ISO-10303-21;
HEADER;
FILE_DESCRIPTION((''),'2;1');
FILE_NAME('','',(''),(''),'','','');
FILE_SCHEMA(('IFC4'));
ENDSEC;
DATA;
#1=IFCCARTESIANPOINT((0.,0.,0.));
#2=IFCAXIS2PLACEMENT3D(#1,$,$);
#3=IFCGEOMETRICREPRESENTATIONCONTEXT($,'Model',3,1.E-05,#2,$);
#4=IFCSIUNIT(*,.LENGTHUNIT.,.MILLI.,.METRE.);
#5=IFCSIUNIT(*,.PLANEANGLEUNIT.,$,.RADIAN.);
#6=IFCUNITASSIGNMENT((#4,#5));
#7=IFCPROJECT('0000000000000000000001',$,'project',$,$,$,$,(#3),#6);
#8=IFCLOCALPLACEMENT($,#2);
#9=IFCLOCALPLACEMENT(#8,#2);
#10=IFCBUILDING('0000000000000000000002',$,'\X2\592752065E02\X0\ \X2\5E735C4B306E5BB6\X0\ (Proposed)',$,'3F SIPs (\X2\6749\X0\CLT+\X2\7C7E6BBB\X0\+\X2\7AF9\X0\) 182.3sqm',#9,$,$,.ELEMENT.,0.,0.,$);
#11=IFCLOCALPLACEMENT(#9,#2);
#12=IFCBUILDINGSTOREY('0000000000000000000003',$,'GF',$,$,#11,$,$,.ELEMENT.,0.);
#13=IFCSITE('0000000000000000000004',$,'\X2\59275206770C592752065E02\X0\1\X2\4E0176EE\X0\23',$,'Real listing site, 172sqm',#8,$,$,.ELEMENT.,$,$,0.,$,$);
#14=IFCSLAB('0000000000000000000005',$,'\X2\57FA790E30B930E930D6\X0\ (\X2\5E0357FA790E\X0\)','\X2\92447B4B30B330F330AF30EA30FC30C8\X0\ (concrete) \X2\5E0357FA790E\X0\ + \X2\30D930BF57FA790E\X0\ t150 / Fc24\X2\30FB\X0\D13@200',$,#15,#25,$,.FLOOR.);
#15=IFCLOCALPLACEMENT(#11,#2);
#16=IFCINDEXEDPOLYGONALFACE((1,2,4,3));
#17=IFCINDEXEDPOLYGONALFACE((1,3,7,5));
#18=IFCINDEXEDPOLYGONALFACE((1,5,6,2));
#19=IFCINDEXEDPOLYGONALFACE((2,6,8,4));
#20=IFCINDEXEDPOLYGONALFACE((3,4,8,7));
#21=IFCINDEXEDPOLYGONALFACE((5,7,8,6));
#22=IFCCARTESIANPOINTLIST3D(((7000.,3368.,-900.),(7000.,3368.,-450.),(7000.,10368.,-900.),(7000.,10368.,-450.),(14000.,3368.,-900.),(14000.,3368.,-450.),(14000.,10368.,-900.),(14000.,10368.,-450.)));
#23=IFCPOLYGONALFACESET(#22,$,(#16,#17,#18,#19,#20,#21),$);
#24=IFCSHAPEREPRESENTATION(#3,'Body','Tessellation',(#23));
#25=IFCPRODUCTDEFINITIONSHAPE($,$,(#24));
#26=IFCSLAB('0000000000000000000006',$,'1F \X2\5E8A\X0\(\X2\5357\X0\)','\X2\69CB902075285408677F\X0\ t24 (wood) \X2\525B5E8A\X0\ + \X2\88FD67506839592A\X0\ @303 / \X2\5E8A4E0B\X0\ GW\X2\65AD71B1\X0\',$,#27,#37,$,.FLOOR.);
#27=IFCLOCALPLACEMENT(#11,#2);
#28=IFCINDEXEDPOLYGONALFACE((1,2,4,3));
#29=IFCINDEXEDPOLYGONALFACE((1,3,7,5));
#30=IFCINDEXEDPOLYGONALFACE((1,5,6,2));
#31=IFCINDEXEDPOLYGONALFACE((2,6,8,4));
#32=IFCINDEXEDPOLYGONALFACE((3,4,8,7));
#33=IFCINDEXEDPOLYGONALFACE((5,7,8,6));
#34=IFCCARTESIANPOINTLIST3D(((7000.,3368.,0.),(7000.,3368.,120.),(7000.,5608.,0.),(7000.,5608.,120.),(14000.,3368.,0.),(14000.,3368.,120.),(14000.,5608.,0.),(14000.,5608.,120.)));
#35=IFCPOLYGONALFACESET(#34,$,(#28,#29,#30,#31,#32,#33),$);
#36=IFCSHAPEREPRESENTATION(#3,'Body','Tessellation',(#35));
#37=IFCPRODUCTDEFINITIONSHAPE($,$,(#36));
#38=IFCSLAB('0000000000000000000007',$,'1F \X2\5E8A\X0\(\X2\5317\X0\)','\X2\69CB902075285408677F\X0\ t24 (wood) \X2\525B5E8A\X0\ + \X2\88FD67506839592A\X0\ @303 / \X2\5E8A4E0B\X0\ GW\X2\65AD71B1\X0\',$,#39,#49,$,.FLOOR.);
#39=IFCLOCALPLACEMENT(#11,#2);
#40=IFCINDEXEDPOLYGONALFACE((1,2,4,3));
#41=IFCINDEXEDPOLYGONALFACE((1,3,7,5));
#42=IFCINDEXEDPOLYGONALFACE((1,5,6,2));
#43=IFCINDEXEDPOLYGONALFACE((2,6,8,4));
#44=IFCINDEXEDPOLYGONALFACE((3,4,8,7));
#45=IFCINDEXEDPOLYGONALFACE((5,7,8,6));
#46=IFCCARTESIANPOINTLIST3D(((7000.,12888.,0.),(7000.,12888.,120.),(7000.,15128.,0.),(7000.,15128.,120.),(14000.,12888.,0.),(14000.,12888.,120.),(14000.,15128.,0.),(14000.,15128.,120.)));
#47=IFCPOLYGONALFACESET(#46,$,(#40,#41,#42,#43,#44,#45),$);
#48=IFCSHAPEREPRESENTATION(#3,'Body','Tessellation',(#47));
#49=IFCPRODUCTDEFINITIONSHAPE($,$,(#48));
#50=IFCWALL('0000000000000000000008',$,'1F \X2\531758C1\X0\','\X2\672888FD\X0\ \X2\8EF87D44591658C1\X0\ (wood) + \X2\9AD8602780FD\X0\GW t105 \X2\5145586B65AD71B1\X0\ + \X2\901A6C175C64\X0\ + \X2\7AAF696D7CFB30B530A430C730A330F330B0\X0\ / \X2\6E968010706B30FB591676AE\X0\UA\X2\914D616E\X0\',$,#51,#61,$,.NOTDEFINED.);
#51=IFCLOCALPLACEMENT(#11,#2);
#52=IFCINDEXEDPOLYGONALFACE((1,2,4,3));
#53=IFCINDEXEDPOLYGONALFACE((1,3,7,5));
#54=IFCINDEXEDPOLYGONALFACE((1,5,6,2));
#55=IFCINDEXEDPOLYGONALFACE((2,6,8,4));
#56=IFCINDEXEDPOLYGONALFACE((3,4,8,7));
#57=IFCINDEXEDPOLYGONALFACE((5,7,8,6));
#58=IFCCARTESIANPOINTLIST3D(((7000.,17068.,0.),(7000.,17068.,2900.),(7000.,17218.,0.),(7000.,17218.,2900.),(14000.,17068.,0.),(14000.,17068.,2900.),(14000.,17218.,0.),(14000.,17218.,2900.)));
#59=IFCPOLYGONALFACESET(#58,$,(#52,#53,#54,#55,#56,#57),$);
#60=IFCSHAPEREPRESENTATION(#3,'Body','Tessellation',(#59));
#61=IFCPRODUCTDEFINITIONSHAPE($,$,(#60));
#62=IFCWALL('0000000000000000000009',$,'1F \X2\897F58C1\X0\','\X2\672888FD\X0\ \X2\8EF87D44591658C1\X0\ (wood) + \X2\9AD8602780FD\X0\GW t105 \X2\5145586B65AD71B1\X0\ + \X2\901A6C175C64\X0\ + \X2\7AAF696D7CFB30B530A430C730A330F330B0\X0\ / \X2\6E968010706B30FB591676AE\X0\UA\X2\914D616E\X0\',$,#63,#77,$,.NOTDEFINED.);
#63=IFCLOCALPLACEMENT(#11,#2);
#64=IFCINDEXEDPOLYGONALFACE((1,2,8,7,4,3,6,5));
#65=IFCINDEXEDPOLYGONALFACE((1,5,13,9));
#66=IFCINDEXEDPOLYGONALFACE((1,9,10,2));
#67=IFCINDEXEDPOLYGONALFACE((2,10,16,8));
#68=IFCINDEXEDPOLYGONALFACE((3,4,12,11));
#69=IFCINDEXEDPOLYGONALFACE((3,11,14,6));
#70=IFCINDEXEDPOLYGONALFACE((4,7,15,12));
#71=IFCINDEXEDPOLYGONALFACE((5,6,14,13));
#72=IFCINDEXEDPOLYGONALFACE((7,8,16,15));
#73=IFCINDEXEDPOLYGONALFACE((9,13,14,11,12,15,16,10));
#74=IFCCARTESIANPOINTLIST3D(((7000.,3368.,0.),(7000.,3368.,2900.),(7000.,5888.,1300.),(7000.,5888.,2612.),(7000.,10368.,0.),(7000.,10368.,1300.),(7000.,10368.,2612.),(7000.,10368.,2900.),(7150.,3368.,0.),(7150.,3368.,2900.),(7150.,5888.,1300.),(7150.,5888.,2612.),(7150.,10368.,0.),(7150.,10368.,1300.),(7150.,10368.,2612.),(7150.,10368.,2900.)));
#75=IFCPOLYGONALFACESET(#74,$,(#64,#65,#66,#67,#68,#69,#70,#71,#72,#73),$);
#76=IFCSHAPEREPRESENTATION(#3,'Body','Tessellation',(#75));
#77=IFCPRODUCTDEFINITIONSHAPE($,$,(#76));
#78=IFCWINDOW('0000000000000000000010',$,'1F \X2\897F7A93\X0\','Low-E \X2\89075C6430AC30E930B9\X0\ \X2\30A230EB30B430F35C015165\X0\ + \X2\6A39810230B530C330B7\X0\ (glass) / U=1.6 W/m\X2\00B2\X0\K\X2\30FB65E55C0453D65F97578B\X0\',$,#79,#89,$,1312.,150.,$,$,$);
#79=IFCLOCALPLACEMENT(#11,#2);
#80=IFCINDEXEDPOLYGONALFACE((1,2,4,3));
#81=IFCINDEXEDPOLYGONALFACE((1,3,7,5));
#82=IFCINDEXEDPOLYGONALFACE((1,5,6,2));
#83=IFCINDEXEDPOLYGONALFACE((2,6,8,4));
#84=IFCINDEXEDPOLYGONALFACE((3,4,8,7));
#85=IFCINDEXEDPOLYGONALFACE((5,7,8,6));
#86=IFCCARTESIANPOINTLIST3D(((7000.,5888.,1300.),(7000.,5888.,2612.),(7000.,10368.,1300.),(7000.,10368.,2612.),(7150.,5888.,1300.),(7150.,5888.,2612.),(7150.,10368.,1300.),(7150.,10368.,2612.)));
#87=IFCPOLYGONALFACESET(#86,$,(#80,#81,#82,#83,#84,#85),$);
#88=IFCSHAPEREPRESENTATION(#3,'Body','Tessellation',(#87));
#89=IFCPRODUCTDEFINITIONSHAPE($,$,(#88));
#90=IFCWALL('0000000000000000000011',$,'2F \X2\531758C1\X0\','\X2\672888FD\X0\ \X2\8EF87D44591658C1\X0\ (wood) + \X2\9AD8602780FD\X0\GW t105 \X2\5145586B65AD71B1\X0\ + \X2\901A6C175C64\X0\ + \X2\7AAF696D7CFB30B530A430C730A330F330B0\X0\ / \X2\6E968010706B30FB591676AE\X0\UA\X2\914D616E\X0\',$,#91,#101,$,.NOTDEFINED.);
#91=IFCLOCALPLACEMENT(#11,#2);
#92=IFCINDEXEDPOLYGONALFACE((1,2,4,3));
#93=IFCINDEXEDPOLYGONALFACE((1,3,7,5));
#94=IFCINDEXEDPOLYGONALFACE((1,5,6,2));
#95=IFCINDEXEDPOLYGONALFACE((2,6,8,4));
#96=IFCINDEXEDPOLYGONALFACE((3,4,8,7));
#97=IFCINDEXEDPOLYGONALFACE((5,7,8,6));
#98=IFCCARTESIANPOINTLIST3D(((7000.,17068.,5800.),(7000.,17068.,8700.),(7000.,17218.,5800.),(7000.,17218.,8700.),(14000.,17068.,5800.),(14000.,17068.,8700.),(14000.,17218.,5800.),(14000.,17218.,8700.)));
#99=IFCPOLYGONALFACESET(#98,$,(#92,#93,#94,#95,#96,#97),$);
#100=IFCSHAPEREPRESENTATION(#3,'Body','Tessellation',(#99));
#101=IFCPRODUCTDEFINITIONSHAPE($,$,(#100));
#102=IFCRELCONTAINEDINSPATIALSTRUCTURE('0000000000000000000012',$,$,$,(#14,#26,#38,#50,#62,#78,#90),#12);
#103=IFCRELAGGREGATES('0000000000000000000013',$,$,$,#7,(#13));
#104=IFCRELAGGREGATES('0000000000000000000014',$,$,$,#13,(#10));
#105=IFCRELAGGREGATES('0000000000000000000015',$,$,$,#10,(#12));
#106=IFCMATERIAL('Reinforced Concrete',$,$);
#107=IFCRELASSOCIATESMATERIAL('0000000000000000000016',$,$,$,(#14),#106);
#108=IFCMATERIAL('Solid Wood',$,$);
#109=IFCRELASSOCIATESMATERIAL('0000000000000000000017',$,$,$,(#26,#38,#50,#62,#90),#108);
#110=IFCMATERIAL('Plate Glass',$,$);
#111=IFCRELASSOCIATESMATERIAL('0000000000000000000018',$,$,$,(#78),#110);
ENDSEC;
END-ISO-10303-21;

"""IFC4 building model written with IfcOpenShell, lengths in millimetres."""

from ifc_helpers import new_model, si_unit, frame, frame_2d, origin, place, context, project, spatial, rectangle, extrude, material, element, fill, save


model = new_model("IFC4")

# Units and contexts
model_context = context("Model", 3, precision=1e-05, world=origin())
ifc_project = project(units=[si_unit("LENGTHUNIT", "METRE", prefix="MILLI"), si_unit("PLANEANGLEUNIT", "RADIAN")], contexts=[model_context])

# Site, building, storey
site_placement = place(None, origin())
site = spatial("IfcSite", under=ifc_project, at=site_placement, Name="大分県大分市1丁目23", ObjectType="Real listing site, 172sqm", CompositionType="ELEMENT", RefElevation=0.0)
building_placement = place(site_placement, origin())
building = spatial("IfcBuilding", under=site, at=building_placement, Name="大分市 平屋の家 (Proposed)", ObjectType="3F SIPs (杉CLT+籾殻+竹) 182.3sqm", CompositionType="ELEMENT", ElevationOfRefHeight=0.0, ElevationOfTerrain=0.0)
storey_placement = place(building_placement, origin())
storey = spatial("IfcBuildingStorey", under=building, at=storey_placement, Name="GF", CompositionType="ELEMENT", Elevation=0.0)

# Slabs
ifc_material_1 = material(Name="Reinforced Concrete")
slab_1_placement = place(storey_placement, frame((3500.0, 1684.0, -450.0)))
element("IfcSlab", 1, at=slab_1_placement, inside=storey, material=ifc_material_1, Name="基礎スラブ (布基礎)", Description="鉄筋コンクリート (concrete) 布基礎 + ベタ基礎 t150 / Fc24・D13@200", PredefinedType="FLOOR", context=model_context, shape_type="SweptSolid", body=[
    extrude(rectangle(XDim=7000.0, YDim=7000.0, at=frame_2d((3500.0, 3500.0))), frame((3500.0, 1684.0, -450.0)), (0.0, 0.0, 1.0), 450.0),
])
ifc_material_2 = material(Name="Solid Wood")
slab_2_placement = place(storey_placement, frame((3500.0, 1684.0, 0.0)))
element("IfcSlab", 2, at=slab_2_placement, inside=storey, material=ifc_material_2, Name="1F 床(南)", Description="構造用合板 t24 (wood) 剛床 + 製材根太 @303 / 床下 GW断熱", PredefinedType="FLOOR", context=model_context, shape_type="SweptSolid", body=[
    extrude(rectangle(XDim=7000.0, YDim=2240.0, at=frame_2d((3500.0, 1120.0))), frame((3500.0, 1684.0, 0.0)), (0.0, 0.0, 1.0), 120.0),
])
slab_3_placement = place(storey_placement, frame((3500.0, 6444.0, 0.0)))
element("IfcSlab", 3, at=slab_3_placement, inside=storey, material=ifc_material_2, Name="1F 床(北)", Description="構造用合板 t24 (wood) 剛床 + 製材根太 @303 / 床下 GW断熱", PredefinedType="FLOOR", context=model_context, shape_type="SweptSolid", body=[
    extrude(rectangle(XDim=7000.0, YDim=2240.0, at=frame_2d((3500.0, 1120.0))), frame((3500.0, 6444.0, 0.0)), (0.0, 0.0, 1.0), 120.0),
])

# Shared definitions
ifc_material_3 = material(Name="Plate Glass")

# Wall
wall_1_placement = place(storey_placement, frame((3500.0, 8534.0, 0.0)))
element("IfcWall", 4, at=wall_1_placement, inside=storey, material=ifc_material_2, Name="1F 北壁", Description="木製 軸組外壁 (wood) + 高性能GW t105 充填断熱 + 通気層 + 窯業系サイディング / 準耐火・外皮UA配慮", PredefinedType="NOTDEFINED", context=model_context, shape_type="SweptSolid", body=[
    extrude(rectangle(XDim=7000.0, YDim=150.0, at=frame_2d((3500.0, 75.0))), frame((3500.0, 8534.0, 0.0)), (0.0, 0.0, 1.0), 2900.0),
])

# Wall, opening, window
wall_2_placement = place(storey_placement, frame((3500.0, 1684.0, 0.0)))
wall_2 = element("IfcWall", 5, at=wall_2_placement, inside=storey, material=ifc_material_2, Name="1F 西壁", Description="木製 軸組外壁 (wood) + 高性能GW t105 充填断熱 + 通気層 + 窯業系サイディング / 準耐火・外皮UA配慮", PredefinedType="NOTDEFINED", context=model_context, shape_type="SweptSolid", body=[
    extrude(rectangle(XDim=150.0, YDim=7000.0, at=frame_2d((75.0, 3500.0))), frame((3500.0, 1684.0, 0.0)), (0.0, 0.0, 1.0), 2900.0),
])
opening_1_placement = place(storey_placement, frame((3500.0, 2944.0, 650.0)))
opening_1 = element("IfcOpeningElement", 6, at=opening_1_placement, cuts=wall_2, PredefinedType="NOTDEFINED", context=model_context, shape_type="SweptSolid", body=[
    extrude(rectangle(XDim=150.0, YDim=4480.0, at=frame_2d((75.0, 2240.0))), frame((3500.0, 2944.0, 650.0)), (0.0, 0.0, 1.0), 1312.0),
])
window_1_placement = place(storey_placement, frame((3500.0, 2944.0, 650.0)))
window_1 = element("IfcWindow", 7, at=window_1_placement, inside=storey, material=ifc_material_3, Name="1F 西窓", Description="Low-E 複層ガラス アルゴン封入 + 樹脂サッシ (glass) / U=1.6 W/m²K・日射取得型", OverallHeight=1312.0, OverallWidth=150.0, context=model_context, shape_type="SweptSolid", body=[
    extrude(rectangle(XDim=150.0, YDim=4480.0, at=frame_2d((75.0, 2240.0))), frame((3500.0, 2944.0, 650.0)), (0.0, 0.0, 1.0), 1312.0),
])
fill(opening_1, window_1)

# Wall
wall_3_placement = place(storey_placement, frame((3500.0, 8534.0, 2900.0)))
element("IfcWall", 8, at=wall_3_placement, inside=storey, material=ifc_material_2, Name="2F 北壁", Description="木製 軸組外壁 (wood) + 高性能GW t105 充填断熱 + 通気層 + 窯業系サイディング / 準耐火・外皮UA配慮", PredefinedType="NOTDEFINED", context=model_context, shape_type="SweptSolid", body=[
    extrude(rectangle(XDim=7000.0, YDim=150.0, at=frame_2d((3500.0, 75.0))), frame((3500.0, 8534.0, 2900.0)), (0.0, 0.0, 1.0), 2900.0),
])

save(model, "model.ifc")
